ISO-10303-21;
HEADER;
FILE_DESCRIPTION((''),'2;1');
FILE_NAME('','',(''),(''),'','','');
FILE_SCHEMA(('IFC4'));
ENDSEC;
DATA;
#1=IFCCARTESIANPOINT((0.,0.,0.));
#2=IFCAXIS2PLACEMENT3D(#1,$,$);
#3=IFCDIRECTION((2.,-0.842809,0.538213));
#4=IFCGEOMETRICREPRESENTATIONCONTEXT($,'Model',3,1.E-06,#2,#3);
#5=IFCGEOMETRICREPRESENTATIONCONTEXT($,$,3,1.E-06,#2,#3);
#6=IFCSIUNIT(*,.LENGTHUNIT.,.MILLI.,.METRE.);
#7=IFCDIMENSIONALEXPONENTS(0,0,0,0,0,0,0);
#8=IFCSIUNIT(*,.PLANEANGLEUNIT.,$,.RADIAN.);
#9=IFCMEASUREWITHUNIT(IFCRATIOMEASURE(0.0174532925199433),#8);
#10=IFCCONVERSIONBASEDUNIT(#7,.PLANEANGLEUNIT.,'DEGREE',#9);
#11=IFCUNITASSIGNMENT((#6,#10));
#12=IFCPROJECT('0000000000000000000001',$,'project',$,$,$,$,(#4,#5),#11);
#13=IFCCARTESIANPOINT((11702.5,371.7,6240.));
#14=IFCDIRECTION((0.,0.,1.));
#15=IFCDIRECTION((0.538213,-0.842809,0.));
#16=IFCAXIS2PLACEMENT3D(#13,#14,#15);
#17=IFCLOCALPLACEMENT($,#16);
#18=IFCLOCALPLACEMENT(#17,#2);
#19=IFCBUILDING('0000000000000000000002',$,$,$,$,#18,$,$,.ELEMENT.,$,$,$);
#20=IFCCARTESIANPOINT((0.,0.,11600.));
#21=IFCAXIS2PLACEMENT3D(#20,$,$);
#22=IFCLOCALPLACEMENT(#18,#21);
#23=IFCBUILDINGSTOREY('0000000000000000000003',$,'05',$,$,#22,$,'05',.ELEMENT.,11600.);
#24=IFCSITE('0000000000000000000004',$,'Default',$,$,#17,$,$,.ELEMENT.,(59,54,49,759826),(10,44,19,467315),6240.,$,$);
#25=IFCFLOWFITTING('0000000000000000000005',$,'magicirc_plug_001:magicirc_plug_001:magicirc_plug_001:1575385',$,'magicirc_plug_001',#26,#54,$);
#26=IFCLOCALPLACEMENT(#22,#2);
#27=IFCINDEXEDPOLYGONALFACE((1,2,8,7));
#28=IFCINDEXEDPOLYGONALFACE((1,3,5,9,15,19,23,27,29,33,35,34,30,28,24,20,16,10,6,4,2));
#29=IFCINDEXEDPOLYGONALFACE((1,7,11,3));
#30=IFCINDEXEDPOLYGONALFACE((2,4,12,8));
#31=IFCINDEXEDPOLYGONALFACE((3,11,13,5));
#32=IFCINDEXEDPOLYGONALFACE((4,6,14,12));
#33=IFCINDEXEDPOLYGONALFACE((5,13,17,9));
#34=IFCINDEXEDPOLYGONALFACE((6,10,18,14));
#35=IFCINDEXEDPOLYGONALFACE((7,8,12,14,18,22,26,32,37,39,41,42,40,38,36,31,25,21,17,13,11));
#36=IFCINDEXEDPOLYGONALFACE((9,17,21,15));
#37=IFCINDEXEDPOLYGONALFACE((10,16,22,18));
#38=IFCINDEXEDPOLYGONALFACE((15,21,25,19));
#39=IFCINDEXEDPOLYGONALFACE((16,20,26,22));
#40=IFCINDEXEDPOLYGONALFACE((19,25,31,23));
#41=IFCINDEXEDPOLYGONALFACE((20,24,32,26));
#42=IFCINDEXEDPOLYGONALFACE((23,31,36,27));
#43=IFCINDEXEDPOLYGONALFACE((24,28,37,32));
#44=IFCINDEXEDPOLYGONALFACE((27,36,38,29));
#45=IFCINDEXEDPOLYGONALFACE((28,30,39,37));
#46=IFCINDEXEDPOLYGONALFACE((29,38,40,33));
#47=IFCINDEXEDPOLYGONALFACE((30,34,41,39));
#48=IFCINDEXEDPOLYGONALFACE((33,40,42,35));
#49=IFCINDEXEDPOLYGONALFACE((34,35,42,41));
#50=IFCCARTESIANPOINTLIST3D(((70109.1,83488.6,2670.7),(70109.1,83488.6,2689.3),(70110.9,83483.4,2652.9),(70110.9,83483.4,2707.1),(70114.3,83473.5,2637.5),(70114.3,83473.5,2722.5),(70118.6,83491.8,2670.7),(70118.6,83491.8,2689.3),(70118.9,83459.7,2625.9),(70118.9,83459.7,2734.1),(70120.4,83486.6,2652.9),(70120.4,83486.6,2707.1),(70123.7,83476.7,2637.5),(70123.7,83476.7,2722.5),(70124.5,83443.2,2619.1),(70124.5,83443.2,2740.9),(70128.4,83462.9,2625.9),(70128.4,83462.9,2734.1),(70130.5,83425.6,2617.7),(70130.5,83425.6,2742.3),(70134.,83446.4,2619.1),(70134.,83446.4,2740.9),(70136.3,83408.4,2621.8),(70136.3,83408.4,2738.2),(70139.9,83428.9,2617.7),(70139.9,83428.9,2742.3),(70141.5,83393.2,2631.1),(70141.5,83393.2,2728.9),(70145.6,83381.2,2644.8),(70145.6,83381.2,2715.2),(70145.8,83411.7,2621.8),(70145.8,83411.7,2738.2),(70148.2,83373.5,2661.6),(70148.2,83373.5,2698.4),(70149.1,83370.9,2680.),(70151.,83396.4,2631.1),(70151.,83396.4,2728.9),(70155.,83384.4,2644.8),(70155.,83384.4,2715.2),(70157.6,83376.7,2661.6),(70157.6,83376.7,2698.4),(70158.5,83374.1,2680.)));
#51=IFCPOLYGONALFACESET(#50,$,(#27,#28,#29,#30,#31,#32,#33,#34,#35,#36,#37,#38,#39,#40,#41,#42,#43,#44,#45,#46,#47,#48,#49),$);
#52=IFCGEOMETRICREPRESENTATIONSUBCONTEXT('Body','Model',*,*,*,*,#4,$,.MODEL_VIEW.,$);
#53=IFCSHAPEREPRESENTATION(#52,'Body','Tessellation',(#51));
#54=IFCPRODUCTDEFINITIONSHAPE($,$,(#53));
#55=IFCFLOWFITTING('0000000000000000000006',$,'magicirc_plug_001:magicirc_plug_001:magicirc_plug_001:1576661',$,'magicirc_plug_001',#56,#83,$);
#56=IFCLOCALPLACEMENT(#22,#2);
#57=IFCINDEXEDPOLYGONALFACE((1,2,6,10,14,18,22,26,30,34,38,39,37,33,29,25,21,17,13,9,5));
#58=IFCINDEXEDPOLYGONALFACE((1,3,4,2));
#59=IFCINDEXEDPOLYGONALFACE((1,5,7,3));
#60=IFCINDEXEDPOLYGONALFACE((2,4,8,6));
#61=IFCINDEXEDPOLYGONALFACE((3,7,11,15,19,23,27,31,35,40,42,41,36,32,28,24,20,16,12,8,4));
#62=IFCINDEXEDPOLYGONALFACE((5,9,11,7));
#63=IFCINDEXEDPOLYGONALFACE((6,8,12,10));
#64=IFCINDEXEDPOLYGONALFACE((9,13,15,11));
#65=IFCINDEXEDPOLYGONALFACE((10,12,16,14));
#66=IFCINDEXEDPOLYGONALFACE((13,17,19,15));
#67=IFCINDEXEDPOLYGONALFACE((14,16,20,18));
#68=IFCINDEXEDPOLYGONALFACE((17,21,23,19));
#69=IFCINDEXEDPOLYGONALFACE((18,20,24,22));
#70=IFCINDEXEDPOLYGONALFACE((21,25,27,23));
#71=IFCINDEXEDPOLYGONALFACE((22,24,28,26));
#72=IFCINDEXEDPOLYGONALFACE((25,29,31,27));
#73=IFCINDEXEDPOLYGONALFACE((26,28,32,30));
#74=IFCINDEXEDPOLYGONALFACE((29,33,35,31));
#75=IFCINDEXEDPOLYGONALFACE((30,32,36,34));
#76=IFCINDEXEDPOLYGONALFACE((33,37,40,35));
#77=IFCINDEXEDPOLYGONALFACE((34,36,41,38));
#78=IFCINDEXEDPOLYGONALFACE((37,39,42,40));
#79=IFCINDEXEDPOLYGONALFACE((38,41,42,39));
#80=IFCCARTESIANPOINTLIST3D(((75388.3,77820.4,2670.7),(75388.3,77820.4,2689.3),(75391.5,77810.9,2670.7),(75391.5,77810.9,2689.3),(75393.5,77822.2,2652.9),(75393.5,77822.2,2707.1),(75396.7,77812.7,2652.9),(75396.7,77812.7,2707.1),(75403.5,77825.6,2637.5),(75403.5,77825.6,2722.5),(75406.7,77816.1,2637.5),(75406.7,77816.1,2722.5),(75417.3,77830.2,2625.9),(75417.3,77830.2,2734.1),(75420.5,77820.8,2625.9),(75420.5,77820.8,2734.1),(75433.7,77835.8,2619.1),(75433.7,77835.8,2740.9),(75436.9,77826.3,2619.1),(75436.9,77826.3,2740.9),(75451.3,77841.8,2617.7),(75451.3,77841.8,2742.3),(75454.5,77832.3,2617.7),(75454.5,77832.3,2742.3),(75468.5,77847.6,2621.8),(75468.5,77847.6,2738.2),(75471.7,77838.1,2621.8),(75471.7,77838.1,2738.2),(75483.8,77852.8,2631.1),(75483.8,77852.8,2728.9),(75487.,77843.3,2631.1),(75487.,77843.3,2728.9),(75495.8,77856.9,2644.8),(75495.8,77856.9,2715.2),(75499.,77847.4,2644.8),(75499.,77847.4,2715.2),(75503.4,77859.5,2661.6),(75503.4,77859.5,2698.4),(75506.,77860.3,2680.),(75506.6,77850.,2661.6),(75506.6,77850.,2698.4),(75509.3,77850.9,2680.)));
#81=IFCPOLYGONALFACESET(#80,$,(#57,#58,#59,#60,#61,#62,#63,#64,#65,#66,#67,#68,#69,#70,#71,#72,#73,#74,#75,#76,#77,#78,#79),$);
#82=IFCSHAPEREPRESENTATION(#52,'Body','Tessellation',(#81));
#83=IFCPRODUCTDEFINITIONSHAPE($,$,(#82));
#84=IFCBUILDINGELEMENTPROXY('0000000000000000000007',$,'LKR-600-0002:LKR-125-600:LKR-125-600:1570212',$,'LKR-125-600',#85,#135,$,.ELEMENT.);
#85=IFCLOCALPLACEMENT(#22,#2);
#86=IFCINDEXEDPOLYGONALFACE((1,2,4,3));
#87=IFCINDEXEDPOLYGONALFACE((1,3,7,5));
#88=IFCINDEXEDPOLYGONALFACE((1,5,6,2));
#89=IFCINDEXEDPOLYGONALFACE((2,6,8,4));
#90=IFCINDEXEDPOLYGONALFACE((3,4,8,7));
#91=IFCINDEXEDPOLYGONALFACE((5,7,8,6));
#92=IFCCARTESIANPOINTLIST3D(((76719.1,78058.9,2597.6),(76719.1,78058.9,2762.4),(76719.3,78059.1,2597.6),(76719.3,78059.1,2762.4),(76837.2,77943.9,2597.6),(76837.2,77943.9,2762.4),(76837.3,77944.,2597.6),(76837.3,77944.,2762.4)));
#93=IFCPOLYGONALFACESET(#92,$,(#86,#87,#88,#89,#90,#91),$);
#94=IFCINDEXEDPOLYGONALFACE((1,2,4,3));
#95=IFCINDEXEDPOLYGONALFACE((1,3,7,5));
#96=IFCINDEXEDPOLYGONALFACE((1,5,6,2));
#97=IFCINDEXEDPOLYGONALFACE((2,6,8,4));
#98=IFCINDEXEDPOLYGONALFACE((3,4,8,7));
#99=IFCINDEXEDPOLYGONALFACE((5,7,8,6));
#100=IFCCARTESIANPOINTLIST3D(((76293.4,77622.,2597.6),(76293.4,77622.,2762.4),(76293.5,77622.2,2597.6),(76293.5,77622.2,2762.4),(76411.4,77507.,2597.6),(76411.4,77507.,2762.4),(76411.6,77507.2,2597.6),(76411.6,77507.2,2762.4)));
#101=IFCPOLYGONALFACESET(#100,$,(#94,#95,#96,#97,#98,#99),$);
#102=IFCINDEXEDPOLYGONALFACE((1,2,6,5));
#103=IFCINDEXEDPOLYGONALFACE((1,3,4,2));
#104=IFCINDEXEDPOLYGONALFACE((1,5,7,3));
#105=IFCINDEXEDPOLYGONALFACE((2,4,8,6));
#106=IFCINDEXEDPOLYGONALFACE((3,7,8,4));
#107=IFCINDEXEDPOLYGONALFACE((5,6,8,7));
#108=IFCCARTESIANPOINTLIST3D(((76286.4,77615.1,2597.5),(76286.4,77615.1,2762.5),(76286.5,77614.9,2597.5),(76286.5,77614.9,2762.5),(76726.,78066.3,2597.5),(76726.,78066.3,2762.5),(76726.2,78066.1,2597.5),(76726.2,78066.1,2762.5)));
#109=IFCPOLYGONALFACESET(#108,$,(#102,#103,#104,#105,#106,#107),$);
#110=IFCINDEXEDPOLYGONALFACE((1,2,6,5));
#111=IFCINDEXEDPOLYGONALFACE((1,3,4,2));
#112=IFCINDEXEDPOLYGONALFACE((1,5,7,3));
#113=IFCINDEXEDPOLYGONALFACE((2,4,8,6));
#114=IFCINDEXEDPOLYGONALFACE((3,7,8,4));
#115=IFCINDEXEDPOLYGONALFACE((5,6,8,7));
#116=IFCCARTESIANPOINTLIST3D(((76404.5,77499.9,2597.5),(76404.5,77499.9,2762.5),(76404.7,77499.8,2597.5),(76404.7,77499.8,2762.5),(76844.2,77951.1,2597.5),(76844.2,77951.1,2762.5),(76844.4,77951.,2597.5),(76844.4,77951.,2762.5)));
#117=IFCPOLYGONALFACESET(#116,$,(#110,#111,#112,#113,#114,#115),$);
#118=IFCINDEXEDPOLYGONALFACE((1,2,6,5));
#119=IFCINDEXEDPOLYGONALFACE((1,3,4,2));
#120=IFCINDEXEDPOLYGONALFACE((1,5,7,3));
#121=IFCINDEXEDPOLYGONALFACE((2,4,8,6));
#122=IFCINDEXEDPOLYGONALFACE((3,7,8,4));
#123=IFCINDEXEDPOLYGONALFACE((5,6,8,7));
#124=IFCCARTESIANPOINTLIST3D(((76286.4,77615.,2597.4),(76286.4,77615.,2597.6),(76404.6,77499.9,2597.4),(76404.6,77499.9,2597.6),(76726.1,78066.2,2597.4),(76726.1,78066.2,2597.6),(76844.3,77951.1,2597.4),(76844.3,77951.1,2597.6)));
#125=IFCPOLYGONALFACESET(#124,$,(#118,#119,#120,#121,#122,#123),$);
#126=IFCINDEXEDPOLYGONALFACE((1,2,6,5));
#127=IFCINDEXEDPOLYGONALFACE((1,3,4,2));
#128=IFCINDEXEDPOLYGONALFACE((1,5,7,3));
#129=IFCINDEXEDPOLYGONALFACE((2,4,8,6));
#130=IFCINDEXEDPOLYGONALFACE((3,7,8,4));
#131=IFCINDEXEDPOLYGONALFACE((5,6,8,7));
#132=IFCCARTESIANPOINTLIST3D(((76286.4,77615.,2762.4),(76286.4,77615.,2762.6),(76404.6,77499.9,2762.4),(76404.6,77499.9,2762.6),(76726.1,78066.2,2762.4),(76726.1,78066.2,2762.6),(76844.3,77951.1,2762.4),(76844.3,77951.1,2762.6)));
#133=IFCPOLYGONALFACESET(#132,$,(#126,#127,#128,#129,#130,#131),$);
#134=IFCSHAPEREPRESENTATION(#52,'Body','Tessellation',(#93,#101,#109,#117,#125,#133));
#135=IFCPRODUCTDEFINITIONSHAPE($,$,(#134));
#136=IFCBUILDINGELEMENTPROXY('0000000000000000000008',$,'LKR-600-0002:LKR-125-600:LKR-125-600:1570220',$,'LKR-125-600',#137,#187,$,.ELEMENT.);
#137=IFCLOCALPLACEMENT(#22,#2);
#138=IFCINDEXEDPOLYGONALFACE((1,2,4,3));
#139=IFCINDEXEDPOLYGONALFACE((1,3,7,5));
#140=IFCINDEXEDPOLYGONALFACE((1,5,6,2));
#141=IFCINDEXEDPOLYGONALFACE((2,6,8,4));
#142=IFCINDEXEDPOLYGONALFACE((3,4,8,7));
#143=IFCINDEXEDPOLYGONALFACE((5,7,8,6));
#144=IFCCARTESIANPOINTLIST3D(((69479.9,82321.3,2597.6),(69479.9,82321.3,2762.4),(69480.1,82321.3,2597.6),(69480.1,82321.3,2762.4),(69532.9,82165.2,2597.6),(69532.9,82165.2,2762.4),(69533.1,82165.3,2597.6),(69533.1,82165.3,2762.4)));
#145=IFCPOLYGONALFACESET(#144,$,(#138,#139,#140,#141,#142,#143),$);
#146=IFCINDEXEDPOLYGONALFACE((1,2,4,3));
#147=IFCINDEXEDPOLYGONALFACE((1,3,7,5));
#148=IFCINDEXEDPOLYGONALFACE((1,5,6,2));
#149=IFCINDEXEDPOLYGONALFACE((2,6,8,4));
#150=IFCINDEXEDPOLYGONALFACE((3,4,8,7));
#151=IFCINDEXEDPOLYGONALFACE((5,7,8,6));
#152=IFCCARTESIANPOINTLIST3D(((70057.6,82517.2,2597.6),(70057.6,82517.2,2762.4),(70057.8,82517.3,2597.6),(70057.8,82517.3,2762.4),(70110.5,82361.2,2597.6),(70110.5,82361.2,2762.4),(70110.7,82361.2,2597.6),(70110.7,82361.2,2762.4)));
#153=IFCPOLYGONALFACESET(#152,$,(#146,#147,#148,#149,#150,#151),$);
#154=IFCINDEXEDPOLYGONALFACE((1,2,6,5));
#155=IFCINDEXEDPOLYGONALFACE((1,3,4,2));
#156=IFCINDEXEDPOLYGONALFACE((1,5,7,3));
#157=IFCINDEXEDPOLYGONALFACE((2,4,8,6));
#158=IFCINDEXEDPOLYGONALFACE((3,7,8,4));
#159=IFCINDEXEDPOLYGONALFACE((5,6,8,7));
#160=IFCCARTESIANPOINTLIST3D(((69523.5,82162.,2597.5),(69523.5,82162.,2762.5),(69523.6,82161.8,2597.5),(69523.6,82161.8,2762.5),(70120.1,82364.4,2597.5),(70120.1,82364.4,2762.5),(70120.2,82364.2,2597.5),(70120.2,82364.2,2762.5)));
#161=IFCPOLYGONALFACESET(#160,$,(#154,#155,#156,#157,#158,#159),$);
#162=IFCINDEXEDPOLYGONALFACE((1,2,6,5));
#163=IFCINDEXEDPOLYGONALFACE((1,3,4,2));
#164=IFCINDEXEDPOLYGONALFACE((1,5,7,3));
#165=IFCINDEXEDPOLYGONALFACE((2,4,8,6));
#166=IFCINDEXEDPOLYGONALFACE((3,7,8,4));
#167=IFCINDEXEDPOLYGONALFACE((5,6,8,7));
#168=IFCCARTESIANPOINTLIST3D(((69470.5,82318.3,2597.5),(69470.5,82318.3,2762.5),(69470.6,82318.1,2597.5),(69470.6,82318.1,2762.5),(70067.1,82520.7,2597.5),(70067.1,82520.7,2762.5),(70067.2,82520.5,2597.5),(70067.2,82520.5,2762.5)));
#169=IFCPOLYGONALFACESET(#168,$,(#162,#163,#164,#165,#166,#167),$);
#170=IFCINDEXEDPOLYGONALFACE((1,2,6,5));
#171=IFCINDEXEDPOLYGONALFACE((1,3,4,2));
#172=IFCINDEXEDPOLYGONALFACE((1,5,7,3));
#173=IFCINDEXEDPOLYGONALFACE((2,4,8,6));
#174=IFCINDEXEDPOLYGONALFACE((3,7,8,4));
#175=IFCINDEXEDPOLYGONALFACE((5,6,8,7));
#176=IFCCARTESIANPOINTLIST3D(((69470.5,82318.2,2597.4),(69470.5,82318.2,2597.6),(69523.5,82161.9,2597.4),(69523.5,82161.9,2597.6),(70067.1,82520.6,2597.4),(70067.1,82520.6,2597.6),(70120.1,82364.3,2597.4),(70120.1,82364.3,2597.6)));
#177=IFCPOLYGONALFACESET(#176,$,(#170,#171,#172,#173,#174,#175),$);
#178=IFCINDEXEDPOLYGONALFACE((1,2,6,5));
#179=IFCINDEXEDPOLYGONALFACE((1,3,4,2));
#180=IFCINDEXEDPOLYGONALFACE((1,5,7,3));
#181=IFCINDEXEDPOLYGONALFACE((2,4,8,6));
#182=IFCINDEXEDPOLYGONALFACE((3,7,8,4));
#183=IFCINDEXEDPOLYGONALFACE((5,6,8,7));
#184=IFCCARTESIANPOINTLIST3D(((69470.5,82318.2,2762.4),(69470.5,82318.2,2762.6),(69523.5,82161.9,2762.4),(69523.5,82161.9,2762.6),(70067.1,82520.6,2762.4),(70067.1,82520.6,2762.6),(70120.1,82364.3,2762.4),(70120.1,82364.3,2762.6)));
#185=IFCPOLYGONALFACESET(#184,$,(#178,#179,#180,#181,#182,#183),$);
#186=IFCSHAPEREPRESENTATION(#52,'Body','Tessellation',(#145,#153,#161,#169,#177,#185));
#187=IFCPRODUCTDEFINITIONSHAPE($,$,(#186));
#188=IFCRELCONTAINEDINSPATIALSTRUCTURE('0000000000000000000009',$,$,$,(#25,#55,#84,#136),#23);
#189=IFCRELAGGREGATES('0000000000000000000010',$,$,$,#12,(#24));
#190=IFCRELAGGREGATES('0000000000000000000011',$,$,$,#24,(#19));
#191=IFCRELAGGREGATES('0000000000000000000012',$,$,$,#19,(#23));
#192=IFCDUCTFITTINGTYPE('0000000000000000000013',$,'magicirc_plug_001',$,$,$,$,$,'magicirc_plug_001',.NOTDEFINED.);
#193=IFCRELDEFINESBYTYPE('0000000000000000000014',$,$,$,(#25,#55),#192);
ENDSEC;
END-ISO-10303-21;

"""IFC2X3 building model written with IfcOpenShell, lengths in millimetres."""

from ifc_helpers import new_model, entity, si_unit, converted_unit, direction, frame, frame_2d, origin, place, context, subcontext, project, spatial, rectangle, circle, extrude, source, transform, mapped, type_object, type_shapes, element, save


model = new_model("IFC2X3")

# Units and contexts
model_context = context("Model", 3, precision=1e-06, world=origin(), true_north=direction((2.0, -0.842809, 0.538213)))
context_of_model = context(None, 3, precision=1e-06, world=origin(), true_north=direction((2.0, -0.842809, 0.538213)))
body_context = subcontext(model_context, "Body", "Model", "MODEL_VIEW")
ifc_project = project(units=[si_unit("LENGTHUNIT", "METRE", prefix="MILLI"), converted_unit("PLANEANGLEUNIT", "DEGREE", entity("IfcRatioMeasure", 0.0174532925199433), si_unit("PLANEANGLEUNIT", "RADIAN"), dimensions=[0, 0, 0, 0, 0, 0, 0])], contexts=[model_context, context_of_model])

# Site, building, storey
site_placement = place(None, frame((11702.5, 371.7, 6240.0), z_axis=(0.0, 0.0, 1.0), x_axis=(0.538213, -0.842809, 0.0)))
site = spatial("IfcSite", under=ifc_project, at=site_placement, Name="Default", CompositionType="ELEMENT", RefLatitude=(59, 54, 49, 759826), RefLongitude=(10, 44, 19, 467315), RefElevation=6240.0)
building_placement = place(site_placement, origin())
building = spatial("IfcBuilding", under=site, at=building_placement, CompositionType="ELEMENT")
storey_placement = place(building_placement, frame((0.0, 0.0, 11600.0)))
storey = spatial("IfcBuildingStorey", under=building, at=storey_placement, Name="05", LongName="05", CompositionType="ELEMENT", Elevation=11600.0)

# Flow fittings
duct_fitting_type_1 = type_object("IfcDuctFittingType", Name="magicirc_plug_001", ElementType="magicirc_plug_001", PredefinedType="NOTDEFINED")
shared_shape_1 = source(origin(), body_context, "Body", "SweptSolid", [
    extrude(circle(Radius=62.5, at=frame_2d((0.0, 0.0), x_axis=(1.0, 0.0))), frame((0.0, 0.0, 0.0), z_axis=(1.0, 0.0, 0.0), x_axis=(0.0, 1.0, 0.0)), (0.0, 0.0, 1.0), 10.0),
])
type_shapes(duct_fitting_type_1, [shared_shape_1])
for number, where, z_axis, x_axis, name in (
    (1, (70138.4, 83433.3, 2680.0), (0.0, 0.0, 1.0), (-0.946986, -0.321274, 0.0), "magicirc_plug_001:magicirc_plug_001:magicirc_plug_001:1575385"),
    (2, (75446.9, 77840.3, 2680.0), (0.0, 0.0, 1.0), (0.321274, -0.946986, 0.0), "magicirc_plug_001:magicirc_plug_001:magicirc_plug_001:1576661"),
):
    element("IfcFlowFitting", number, at=place(storey_placement, frame(where, z_axis=z_axis, x_axis=x_axis)), inside=storey, type_object=duct_fitting_type_1, Name=name, ObjectType="magicirc_plug_001", context=body_context, shape_type="MappedRepresentation", body=[
        mapped(shared_shape_1, transform((0.0, 0.0, 0.0), scale=1.0)),
    ])

# Building element proxies
shared_shape_2 = source(origin(), body_context, "Body", "SweptSolid", [
    extrude(rectangle(XDim=0.2, YDim=164.8, at=frame_2d((0.0, 0.0), x_axis=(1.0, 0.0))), frame((305.0, 0.0, -82.4)), (0.0, 0.0, 1.0), 164.8),
    extrude(rectangle(XDim=0.2, YDim=164.8, at=frame_2d((0.0, 0.0), x_axis=(1.0, 0.0))), frame((-305.0, 0.0, -82.4)), (0.0, 0.0, 1.0), 164.8),
    extrude(rectangle(XDim=0.2, YDim=630.0, at=frame_2d((0.0, 0.0), x_axis=(1.0, 0.0))), frame((0.0, 82.5, -82.5), z_axis=(0.0, 0.0, 1.0), x_axis=(0.0, 1.0, 0.0)), (0.0, 0.0, 1.0), 165.0),
    extrude(rectangle(XDim=0.2, YDim=630.0, at=frame_2d((0.0, 0.0), x_axis=(1.0, 0.0))), frame((0.0, -82.5, -82.5), z_axis=(0.0, 0.0, 1.0), x_axis=(0.0, 1.0, 0.0)), (0.0, 0.0, 1.0), 165.0),
    extrude(rectangle(XDim=165.0, YDim=630.0, at=frame_2d((0.0, 0.0), x_axis=(1.0, 0.0))), frame((0.0, 0.0, -82.6), z_axis=(0.0, 0.0, 1.0), x_axis=(0.0, -1.0, 0.0)), (0.0, 0.0, 1.0), 0.2),
    extrude(rectangle(XDim=165.0, YDim=630.0, at=frame_2d((0.0, 0.0), x_axis=(1.0, 0.0))), frame((0.0, 0.0, 82.4), z_axis=(0.0, 0.0, 1.0), x_axis=(0.0, -1.0, 0.0)), (0.0, 0.0, 1.0), 0.2),
])
for number, where, z_axis, x_axis, name in (
    (3, (76565.4, 77783.0, 2680.0), (0.0, 0.0, 1.0), (0.697915, 0.71618, 0.0), "LKR-600-0002:LKR-125-600:LKR-125-600:1570212"),
    (4, (69795.3, 82341.3, 2680.0), (0.0, 0.0, 1.0), (-0.946986, -0.321274, 0.0), "LKR-600-0002:LKR-125-600:LKR-125-600:1570220"),
):
    element("IfcBuildingElementProxy", number, at=place(storey_placement, frame(where, z_axis=z_axis, x_axis=x_axis)), inside=storey, Name=name, ObjectType="LKR-125-600", CompositionType="ELEMENT", context=body_context, shape_type="MappedRepresentation", body=[
        mapped(shared_shape_2, transform((0.0, 0.0, 0.0), scale=1.0)),
    ])

save(model, "model.ifc")
